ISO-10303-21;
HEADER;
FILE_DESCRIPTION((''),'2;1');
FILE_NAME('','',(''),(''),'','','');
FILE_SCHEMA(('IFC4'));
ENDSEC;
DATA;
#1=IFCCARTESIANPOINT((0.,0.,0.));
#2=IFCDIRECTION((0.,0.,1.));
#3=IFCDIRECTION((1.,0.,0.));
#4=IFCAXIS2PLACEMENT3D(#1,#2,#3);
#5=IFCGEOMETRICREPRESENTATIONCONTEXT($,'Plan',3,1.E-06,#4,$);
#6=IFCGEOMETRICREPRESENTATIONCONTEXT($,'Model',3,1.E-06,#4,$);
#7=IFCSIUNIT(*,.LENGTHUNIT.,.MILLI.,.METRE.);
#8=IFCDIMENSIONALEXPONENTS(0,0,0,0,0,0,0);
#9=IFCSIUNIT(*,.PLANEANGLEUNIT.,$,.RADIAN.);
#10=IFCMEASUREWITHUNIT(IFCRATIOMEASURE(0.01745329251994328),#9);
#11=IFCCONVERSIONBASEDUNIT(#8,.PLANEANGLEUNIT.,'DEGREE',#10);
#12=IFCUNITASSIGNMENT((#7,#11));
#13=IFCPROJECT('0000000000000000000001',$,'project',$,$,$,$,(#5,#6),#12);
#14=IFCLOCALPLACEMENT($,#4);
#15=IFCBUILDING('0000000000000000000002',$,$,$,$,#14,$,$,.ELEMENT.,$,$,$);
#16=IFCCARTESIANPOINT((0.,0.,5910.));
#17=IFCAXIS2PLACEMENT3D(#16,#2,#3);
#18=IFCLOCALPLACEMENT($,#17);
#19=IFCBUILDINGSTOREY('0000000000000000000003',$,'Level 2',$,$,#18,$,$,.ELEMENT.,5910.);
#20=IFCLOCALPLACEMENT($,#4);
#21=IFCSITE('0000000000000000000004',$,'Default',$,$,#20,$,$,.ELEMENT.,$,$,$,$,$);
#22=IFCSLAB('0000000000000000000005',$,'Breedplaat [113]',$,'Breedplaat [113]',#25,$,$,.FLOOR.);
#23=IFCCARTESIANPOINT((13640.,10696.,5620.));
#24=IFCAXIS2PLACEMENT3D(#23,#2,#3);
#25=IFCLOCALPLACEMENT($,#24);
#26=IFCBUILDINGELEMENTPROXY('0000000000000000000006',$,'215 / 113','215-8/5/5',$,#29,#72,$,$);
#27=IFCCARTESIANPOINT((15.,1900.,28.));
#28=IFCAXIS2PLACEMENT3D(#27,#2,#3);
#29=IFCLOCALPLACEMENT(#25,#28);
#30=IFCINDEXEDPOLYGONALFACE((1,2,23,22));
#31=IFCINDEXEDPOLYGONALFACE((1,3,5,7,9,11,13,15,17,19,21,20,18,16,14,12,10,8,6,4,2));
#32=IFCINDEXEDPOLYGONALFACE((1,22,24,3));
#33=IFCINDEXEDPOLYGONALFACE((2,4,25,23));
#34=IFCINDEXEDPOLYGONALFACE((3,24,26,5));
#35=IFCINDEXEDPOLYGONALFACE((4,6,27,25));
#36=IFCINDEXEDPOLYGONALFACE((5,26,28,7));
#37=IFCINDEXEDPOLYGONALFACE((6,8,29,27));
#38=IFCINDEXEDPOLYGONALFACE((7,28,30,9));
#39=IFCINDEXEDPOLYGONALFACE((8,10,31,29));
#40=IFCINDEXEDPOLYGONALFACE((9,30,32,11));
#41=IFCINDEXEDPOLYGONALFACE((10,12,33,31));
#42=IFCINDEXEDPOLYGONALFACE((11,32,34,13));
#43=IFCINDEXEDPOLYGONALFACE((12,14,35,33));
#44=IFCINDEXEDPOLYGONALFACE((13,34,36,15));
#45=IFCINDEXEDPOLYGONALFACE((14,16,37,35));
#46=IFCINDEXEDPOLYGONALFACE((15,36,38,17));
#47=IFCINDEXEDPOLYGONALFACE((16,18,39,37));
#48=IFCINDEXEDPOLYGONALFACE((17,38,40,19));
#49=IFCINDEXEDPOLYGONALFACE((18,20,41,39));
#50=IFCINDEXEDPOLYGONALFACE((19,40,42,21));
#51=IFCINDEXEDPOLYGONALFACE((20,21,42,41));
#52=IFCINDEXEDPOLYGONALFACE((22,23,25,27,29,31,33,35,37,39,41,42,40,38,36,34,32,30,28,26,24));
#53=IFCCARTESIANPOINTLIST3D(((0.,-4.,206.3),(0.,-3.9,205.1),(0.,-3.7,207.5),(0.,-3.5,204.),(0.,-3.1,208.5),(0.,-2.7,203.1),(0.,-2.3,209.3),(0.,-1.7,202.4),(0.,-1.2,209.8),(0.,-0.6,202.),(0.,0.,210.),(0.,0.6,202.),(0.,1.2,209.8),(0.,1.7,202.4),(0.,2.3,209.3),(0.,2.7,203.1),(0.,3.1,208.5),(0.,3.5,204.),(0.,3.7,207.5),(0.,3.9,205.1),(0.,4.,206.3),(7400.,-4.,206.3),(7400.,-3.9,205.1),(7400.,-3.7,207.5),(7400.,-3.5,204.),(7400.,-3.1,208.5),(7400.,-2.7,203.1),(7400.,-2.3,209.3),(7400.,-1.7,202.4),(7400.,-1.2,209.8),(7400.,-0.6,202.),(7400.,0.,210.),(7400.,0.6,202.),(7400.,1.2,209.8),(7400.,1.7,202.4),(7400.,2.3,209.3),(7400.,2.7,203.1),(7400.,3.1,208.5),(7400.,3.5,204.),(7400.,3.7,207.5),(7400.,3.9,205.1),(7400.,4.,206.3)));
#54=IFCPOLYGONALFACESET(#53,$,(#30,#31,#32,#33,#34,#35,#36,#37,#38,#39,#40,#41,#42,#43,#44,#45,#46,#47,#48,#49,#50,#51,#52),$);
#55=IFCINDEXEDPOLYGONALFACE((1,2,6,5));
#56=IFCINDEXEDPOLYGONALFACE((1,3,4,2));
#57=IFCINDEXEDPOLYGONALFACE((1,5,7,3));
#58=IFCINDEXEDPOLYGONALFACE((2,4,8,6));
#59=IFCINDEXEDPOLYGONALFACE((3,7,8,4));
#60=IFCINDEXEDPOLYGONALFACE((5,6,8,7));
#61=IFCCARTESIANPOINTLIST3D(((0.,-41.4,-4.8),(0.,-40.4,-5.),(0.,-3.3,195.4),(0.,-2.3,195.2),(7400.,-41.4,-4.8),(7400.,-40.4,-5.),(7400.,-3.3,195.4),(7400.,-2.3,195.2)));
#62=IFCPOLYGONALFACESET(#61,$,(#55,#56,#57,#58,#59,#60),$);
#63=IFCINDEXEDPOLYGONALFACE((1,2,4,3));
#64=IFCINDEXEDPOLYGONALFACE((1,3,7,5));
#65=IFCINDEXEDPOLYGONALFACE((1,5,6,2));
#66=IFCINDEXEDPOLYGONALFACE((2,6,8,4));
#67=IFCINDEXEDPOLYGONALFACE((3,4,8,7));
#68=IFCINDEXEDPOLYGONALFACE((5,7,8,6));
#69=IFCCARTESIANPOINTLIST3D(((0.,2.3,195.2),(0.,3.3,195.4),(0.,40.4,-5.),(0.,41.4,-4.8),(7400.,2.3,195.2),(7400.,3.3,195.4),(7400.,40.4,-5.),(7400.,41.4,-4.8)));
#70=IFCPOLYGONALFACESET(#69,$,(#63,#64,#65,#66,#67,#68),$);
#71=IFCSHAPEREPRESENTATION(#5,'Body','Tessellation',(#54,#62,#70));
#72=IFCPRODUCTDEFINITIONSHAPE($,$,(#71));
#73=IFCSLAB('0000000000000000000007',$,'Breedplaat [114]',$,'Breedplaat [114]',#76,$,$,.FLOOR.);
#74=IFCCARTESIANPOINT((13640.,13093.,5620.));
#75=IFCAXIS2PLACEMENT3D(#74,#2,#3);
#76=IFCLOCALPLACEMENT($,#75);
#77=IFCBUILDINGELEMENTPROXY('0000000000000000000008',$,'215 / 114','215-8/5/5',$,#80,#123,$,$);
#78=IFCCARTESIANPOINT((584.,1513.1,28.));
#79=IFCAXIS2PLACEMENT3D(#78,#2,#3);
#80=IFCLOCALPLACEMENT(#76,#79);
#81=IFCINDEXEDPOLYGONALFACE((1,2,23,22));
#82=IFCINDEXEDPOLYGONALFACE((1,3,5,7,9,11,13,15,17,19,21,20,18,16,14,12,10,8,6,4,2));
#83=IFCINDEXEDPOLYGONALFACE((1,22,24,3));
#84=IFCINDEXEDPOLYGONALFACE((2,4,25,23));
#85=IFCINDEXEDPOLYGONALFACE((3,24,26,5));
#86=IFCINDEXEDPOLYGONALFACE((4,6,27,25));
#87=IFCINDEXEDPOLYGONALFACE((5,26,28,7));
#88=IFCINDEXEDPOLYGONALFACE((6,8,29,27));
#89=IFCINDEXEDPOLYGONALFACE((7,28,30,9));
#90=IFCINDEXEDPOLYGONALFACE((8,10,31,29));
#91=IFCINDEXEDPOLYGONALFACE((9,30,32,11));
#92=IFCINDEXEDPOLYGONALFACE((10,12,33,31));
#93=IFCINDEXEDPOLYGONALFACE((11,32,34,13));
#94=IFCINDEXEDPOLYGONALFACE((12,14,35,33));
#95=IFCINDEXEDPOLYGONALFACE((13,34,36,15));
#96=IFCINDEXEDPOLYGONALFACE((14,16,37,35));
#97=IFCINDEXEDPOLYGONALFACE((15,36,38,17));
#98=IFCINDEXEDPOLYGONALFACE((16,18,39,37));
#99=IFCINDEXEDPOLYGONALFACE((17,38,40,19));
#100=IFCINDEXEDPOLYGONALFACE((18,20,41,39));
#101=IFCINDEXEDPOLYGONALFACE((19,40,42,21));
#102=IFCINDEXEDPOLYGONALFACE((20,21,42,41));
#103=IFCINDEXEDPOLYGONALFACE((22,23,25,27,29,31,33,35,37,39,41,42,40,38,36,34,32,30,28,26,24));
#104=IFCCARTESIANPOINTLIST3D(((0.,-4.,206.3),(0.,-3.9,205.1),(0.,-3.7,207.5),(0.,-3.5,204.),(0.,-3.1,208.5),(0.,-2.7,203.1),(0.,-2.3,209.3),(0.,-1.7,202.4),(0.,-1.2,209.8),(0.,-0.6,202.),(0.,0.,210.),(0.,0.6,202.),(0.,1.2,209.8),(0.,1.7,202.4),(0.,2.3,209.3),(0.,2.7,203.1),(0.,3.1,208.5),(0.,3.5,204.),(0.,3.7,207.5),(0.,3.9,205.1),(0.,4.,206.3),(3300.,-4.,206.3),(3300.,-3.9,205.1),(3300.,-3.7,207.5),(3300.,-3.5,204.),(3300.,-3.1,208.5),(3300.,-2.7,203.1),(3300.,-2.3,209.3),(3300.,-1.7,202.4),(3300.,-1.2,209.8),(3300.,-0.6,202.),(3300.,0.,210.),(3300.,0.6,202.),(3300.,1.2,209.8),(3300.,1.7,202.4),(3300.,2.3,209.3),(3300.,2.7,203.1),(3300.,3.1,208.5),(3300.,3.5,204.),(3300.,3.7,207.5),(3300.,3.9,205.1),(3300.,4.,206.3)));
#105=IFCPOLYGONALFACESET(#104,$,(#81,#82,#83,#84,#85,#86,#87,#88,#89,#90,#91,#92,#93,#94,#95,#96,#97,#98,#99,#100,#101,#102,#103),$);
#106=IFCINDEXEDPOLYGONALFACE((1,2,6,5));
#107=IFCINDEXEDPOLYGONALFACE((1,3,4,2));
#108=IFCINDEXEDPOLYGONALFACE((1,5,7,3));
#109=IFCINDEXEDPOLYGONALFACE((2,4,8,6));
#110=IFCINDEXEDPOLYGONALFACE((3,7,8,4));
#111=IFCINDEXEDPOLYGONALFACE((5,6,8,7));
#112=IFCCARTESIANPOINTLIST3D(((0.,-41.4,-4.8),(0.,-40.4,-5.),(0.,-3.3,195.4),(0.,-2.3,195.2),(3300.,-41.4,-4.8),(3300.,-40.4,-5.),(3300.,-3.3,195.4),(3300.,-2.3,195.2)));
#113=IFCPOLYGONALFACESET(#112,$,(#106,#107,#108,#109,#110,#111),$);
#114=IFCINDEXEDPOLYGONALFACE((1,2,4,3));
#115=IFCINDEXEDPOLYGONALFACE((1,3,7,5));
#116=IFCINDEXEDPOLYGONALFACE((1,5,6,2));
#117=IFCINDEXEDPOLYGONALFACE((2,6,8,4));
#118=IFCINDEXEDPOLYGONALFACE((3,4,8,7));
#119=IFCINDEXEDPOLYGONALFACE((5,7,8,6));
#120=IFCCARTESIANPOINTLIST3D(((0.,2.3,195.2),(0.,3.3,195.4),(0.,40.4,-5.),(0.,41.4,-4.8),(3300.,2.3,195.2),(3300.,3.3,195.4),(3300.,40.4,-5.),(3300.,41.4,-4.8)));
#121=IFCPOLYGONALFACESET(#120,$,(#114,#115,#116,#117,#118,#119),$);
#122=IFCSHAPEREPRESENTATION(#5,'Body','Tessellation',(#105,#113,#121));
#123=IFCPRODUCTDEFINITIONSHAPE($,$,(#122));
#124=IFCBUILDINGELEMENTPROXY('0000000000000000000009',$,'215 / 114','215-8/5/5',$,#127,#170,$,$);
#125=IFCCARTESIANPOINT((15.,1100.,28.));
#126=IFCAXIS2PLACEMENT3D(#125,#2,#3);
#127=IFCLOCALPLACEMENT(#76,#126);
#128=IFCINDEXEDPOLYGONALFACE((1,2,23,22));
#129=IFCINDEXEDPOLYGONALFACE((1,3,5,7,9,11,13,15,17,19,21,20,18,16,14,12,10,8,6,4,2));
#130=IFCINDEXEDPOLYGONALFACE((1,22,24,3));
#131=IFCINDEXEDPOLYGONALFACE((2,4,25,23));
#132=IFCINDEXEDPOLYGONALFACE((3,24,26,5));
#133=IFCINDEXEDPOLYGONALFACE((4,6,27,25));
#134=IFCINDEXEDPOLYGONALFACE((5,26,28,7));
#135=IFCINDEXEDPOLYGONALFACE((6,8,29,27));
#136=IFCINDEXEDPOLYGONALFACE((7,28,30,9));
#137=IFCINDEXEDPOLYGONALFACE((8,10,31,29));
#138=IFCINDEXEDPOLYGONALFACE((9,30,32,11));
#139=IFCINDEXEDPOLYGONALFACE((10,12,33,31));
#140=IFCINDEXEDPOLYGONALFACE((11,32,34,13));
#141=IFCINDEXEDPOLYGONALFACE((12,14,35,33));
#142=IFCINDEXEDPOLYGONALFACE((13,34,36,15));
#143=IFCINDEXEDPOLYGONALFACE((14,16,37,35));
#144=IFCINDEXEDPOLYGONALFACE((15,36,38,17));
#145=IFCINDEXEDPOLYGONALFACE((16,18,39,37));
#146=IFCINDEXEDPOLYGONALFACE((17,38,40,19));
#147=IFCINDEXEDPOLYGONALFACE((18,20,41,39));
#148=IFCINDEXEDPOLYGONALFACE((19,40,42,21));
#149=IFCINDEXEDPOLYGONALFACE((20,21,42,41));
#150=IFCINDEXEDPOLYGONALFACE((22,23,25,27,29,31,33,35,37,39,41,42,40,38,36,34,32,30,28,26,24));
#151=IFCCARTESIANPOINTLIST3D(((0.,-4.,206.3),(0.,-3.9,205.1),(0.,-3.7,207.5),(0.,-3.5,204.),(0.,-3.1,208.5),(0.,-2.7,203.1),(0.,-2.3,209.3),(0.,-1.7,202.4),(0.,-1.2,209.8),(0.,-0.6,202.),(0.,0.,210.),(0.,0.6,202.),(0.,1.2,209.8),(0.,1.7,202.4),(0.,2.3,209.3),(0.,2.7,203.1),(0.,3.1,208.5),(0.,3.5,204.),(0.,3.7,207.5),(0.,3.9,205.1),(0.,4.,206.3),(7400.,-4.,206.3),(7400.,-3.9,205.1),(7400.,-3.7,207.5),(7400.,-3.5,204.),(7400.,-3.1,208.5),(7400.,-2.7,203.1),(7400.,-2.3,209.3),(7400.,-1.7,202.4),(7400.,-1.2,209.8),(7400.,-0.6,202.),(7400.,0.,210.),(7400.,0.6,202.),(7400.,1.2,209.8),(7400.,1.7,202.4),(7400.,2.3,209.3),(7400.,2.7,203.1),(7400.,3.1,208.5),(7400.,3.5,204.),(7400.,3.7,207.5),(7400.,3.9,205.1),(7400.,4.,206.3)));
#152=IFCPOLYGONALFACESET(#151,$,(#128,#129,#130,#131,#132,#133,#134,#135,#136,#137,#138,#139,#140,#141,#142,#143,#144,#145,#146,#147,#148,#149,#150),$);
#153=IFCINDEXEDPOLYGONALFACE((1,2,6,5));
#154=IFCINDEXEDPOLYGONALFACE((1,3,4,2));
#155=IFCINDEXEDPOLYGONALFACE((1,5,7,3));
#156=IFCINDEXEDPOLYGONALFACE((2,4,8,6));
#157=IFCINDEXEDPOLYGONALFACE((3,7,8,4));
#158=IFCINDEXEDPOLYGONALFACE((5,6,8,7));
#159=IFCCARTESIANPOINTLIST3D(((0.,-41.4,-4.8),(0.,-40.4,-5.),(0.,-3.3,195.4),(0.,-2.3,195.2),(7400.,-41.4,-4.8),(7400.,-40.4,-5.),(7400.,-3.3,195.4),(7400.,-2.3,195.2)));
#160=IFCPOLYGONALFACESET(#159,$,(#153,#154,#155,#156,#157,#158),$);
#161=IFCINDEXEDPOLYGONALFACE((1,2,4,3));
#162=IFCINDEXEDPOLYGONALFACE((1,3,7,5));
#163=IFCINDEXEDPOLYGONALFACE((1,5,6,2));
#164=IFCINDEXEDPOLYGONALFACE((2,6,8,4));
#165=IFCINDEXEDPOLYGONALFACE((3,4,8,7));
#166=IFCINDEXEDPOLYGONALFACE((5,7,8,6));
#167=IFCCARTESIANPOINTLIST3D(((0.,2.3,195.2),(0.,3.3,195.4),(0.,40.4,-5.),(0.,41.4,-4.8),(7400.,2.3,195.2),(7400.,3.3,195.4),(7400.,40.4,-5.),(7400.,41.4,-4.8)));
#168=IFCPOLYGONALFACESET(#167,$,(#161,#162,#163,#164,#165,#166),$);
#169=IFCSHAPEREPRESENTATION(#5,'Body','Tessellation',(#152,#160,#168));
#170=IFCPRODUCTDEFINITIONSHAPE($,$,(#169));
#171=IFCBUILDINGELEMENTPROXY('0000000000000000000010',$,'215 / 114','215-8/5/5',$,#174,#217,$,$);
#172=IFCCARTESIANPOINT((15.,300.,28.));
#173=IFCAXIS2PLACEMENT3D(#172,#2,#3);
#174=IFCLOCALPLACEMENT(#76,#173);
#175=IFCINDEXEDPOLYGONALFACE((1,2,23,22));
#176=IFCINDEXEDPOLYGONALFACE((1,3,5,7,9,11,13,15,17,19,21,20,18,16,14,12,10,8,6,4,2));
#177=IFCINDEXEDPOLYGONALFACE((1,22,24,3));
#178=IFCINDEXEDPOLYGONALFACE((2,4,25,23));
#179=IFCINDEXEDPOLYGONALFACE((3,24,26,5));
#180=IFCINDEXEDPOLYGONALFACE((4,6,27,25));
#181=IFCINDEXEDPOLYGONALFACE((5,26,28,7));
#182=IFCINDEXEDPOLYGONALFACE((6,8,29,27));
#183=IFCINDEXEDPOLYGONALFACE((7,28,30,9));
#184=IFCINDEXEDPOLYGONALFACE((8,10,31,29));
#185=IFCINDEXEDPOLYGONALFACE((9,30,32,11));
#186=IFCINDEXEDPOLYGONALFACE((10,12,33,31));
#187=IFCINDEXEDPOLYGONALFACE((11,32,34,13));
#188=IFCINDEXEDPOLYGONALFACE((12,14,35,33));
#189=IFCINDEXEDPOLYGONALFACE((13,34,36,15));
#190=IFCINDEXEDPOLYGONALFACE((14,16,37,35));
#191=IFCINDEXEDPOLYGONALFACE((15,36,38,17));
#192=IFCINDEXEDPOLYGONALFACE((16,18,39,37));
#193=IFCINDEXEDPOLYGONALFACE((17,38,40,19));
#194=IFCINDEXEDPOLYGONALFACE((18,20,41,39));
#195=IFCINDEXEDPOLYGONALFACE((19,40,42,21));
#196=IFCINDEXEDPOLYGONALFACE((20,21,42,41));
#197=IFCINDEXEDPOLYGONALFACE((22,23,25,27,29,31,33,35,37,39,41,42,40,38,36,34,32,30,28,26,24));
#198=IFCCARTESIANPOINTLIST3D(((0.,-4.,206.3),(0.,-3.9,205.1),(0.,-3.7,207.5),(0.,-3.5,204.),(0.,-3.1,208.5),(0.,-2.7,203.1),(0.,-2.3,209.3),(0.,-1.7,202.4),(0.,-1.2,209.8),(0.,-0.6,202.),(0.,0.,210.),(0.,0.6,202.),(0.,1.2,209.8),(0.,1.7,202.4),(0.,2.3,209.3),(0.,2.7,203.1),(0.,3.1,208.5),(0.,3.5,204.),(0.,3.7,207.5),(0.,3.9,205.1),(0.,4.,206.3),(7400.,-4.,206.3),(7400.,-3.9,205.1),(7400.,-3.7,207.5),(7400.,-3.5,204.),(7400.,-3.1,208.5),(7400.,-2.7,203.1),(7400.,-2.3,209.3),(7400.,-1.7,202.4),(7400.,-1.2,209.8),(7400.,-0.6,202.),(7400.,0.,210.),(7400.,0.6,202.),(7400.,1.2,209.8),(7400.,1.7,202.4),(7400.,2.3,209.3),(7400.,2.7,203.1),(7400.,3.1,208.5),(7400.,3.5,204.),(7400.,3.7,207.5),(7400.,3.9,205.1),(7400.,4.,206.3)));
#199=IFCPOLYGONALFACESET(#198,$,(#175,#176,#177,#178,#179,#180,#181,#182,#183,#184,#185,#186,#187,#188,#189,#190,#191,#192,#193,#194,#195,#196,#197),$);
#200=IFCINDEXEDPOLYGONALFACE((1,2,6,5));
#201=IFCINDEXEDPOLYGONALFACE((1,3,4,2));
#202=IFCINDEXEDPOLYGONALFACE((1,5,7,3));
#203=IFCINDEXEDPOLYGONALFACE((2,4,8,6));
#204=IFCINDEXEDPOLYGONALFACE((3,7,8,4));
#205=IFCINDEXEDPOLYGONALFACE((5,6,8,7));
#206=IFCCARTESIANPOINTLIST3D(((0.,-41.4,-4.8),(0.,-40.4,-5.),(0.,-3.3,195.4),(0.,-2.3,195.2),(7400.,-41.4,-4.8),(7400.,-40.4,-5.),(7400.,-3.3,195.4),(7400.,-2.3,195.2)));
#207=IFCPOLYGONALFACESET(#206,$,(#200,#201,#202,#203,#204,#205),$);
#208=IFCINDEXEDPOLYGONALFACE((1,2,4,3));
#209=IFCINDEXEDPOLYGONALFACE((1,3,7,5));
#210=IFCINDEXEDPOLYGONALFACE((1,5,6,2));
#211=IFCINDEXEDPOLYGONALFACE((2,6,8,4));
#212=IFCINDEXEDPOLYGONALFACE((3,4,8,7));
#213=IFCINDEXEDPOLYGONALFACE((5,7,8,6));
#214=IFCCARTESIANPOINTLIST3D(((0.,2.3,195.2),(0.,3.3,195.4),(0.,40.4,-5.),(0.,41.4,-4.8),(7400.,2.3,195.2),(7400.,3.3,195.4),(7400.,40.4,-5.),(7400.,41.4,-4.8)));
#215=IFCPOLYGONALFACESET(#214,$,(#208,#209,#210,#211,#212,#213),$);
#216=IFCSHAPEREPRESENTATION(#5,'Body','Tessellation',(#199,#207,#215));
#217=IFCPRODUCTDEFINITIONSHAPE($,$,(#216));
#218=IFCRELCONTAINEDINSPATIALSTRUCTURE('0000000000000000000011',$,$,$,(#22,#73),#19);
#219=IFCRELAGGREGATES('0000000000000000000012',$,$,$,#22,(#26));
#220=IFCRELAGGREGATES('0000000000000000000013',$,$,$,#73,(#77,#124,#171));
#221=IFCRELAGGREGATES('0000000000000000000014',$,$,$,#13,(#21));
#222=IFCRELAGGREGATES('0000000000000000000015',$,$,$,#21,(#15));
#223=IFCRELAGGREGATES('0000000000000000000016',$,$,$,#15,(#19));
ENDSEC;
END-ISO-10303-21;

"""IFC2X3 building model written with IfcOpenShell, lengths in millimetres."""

from ifc_helpers import new_model, entity, si_unit, converted_unit, frame, origin_with_axes, origin_2d_with_axis, place, context, project, spatial, rectangle, circle, extrude, element, aggregate, save


model = new_model("IFC2X3")

# Units and contexts
plan_context = context("Plan", 3, precision=1e-06, world=origin_with_axes())
model_context = context("Model", 3, precision=1e-06, world=origin_with_axes())
ifc_project = project(units=[si_unit("LENGTHUNIT", "METRE", prefix="MILLI"), converted_unit("PLANEANGLEUNIT", "DEGREE", entity("IfcRatioMeasure", 0.01745329251994328), si_unit("PLANEANGLEUNIT", "RADIAN"), dimensions=[0, 0, 0, 0, 0, 0, 0])], contexts=[plan_context, model_context])

# Site, building, storey
site_placement = place(None, origin_with_axes())
site = spatial("IfcSite", under=ifc_project, at=site_placement, Name="Default", CompositionType="ELEMENT")
building_placement = place(None, origin_with_axes())
building = spatial("IfcBuilding", under=site, at=building_placement, CompositionType="ELEMENT")
storey_placement = place(None, frame((0.0, 0.0, 5910.0), z_axis=(0.0, 0.0, 1.0), x_axis=(1.0, 0.0, 0.0)))
storey = spatial("IfcBuildingStorey", under=building, at=storey_placement, Name="Level 2", CompositionType="ELEMENT", Elevation=5910.0)

# Slabs, building element proxies
slab_1_placement = place(None, frame((13640.0, 10696.0, 5620.0), z_axis=(0.0, 0.0, 1.0), x_axis=(1.0, 0.0, 0.0)))
slab_1 = element("IfcSlab", 1, at=slab_1_placement, inside=storey, Name="Breedplaat [113]", ObjectType="Breedplaat [113]", PredefinedType="FLOOR")
proxy_1_placement = place(slab_1_placement, frame((15.0, 1900.0, 28.0), z_axis=(0.0, 0.0, 1.0), x_axis=(1.0, 0.0, 0.0)))
proxy_1 = element("IfcBuildingElementProxy", 2, at=proxy_1_placement, Name="215 / 113", Description="215-8/5/5", context=plan_context, shape_type="SweptSolid", body=[
    extrude(circle(Radius=4.0, at=origin_2d_with_axis()), frame((0.0, 0.0, 206.0), z_axis=(1.0, 0.0, 0.0), x_axis=(0.0, 0.0, 1.0)), (0.0, 0.0, 1.0), 7400.0),
    extrude(rectangle(XDim=203.8, YDim=1.0, at=origin_2d_with_axis()), frame((0.0, -21.9, 95.2), z_axis=(1.0, 0.0, 0.0), x_axis=(0.0, 0.187112, 0.982339)), (0.0, 0.0, 1.0), 7400.0),
    extrude(rectangle(XDim=203.8, YDim=1.0, at=origin_2d_with_axis()), frame((0.0, 21.9, 95.2), z_axis=(1.0, 0.0, 0.0), x_axis=(0.0, -0.187112, 0.982339)), (0.0, 0.0, 1.0), 7400.0),
])
aggregate(slab_1, [proxy_1])
slab_2_placement = place(None, frame((13640.0, 13093.0, 5620.0), z_axis=(0.0, 0.0, 1.0), x_axis=(1.0, 0.0, 0.0)))
slab_2 = element("IfcSlab", 3, at=slab_2_placement, inside=storey, Name="Breedplaat [114]", ObjectType="Breedplaat [114]", PredefinedType="FLOOR")
proxy_2_placement = place(slab_2_placement, frame((584.0, 1513.1, 28.0), z_axis=(0.0, 0.0, 1.0), x_axis=(1.0, 0.0, 0.0)))
proxy_2 = element("IfcBuildingElementProxy", 4, at=proxy_2_placement, Name="215 / 114", Description="215-8/5/5", context=plan_context, shape_type="SweptSolid", body=[
    extrude(circle(Radius=4.0, at=origin_2d_with_axis()), frame((0.0, 0.0, 206.0), z_axis=(1.0, 0.0, 0.0), x_axis=(0.0, 0.0, 1.0)), (0.0, 0.0, 1.0), 3300.0),
    extrude(rectangle(XDim=203.8, YDim=1.0, at=origin_2d_with_axis()), frame((0.0, -21.9, 95.2), z_axis=(1.0, 0.0, 0.0), x_axis=(0.0, 0.187112, 0.982339)), (0.0, 0.0, 1.0), 3300.0),
    extrude(rectangle(XDim=203.8, YDim=1.0, at=origin_2d_with_axis()), frame((0.0, 21.9, 95.2), z_axis=(1.0, 0.0, 0.0), x_axis=(0.0, -0.187112, 0.982339)), (0.0, 0.0, 1.0), 3300.0),
])
proxy_3_placement = place(slab_2_placement, frame((15.0, 1100.0, 28.0), z_axis=(0.0, 0.0, 1.0), x_axis=(1.0, 0.0, 0.0)))
proxy_3 = element("IfcBuildingElementProxy", 5, at=proxy_3_placement, Name="215 / 114", Description="215-8/5/5", context=plan_context, shape_type="SweptSolid", body=[
    extrude(circle(Radius=4.0, at=origin_2d_with_axis()), frame((0.0, 0.0, 206.0), z_axis=(1.0, 0.0, 0.0), x_axis=(0.0, 0.0, 1.0)), (0.0, 0.0, 1.0), 7400.0),
    extrude(rectangle(XDim=203.8, YDim=1.0, at=origin_2d_with_axis()), frame((0.0, -21.9, 95.2), z_axis=(1.0, 0.0, 0.0), x_axis=(0.0, 0.187112, 0.982339)), (0.0, 0.0, 1.0), 7400.0),
    extrude(rectangle(XDim=203.8, YDim=1.0, at=origin_2d_with_axis()), frame((0.0, 21.9, 95.2), z_axis=(1.0, 0.0, 0.0), x_axis=(0.0, -0.187112, 0.982339)), (0.0, 0.0, 1.0), 7400.0),
])
proxy_4_placement = place(slab_2_placement, frame((15.0, 300.0, 28.0), z_axis=(0.0, 0.0, 1.0), x_axis=(1.0, 0.0, 0.0)))
proxy_4 = element("IfcBuildingElementProxy", 6, at=proxy_4_placement, Name="215 / 114", Description="215-8/5/5", context=plan_context, shape_type="SweptSolid", body=[
    extrude(circle(Radius=4.0, at=origin_2d_with_axis()), frame((0.0, 0.0, 206.0), z_axis=(1.0, 0.0, 0.0), x_axis=(0.0, 0.0, 1.0)), (0.0, 0.0, 1.0), 7400.0),
    extrude(rectangle(XDim=203.8, YDim=1.0, at=origin_2d_with_axis()), frame((0.0, -21.9, 95.2), z_axis=(1.0, 0.0, 0.0), x_axis=(0.0, 0.187112, 0.982339)), (0.0, 0.0, 1.0), 7400.0),
    extrude(rectangle(XDim=203.8, YDim=1.0, at=origin_2d_with_axis()), frame((0.0, 21.9, 95.2), z_axis=(1.0, 0.0, 0.0), x_axis=(0.0, -0.187112, 0.982339)), (0.0, 0.0, 1.0), 7400.0),
])
aggregate(slab_2, [proxy_2, proxy_3, proxy_4])

save(model, "model.ifc")
